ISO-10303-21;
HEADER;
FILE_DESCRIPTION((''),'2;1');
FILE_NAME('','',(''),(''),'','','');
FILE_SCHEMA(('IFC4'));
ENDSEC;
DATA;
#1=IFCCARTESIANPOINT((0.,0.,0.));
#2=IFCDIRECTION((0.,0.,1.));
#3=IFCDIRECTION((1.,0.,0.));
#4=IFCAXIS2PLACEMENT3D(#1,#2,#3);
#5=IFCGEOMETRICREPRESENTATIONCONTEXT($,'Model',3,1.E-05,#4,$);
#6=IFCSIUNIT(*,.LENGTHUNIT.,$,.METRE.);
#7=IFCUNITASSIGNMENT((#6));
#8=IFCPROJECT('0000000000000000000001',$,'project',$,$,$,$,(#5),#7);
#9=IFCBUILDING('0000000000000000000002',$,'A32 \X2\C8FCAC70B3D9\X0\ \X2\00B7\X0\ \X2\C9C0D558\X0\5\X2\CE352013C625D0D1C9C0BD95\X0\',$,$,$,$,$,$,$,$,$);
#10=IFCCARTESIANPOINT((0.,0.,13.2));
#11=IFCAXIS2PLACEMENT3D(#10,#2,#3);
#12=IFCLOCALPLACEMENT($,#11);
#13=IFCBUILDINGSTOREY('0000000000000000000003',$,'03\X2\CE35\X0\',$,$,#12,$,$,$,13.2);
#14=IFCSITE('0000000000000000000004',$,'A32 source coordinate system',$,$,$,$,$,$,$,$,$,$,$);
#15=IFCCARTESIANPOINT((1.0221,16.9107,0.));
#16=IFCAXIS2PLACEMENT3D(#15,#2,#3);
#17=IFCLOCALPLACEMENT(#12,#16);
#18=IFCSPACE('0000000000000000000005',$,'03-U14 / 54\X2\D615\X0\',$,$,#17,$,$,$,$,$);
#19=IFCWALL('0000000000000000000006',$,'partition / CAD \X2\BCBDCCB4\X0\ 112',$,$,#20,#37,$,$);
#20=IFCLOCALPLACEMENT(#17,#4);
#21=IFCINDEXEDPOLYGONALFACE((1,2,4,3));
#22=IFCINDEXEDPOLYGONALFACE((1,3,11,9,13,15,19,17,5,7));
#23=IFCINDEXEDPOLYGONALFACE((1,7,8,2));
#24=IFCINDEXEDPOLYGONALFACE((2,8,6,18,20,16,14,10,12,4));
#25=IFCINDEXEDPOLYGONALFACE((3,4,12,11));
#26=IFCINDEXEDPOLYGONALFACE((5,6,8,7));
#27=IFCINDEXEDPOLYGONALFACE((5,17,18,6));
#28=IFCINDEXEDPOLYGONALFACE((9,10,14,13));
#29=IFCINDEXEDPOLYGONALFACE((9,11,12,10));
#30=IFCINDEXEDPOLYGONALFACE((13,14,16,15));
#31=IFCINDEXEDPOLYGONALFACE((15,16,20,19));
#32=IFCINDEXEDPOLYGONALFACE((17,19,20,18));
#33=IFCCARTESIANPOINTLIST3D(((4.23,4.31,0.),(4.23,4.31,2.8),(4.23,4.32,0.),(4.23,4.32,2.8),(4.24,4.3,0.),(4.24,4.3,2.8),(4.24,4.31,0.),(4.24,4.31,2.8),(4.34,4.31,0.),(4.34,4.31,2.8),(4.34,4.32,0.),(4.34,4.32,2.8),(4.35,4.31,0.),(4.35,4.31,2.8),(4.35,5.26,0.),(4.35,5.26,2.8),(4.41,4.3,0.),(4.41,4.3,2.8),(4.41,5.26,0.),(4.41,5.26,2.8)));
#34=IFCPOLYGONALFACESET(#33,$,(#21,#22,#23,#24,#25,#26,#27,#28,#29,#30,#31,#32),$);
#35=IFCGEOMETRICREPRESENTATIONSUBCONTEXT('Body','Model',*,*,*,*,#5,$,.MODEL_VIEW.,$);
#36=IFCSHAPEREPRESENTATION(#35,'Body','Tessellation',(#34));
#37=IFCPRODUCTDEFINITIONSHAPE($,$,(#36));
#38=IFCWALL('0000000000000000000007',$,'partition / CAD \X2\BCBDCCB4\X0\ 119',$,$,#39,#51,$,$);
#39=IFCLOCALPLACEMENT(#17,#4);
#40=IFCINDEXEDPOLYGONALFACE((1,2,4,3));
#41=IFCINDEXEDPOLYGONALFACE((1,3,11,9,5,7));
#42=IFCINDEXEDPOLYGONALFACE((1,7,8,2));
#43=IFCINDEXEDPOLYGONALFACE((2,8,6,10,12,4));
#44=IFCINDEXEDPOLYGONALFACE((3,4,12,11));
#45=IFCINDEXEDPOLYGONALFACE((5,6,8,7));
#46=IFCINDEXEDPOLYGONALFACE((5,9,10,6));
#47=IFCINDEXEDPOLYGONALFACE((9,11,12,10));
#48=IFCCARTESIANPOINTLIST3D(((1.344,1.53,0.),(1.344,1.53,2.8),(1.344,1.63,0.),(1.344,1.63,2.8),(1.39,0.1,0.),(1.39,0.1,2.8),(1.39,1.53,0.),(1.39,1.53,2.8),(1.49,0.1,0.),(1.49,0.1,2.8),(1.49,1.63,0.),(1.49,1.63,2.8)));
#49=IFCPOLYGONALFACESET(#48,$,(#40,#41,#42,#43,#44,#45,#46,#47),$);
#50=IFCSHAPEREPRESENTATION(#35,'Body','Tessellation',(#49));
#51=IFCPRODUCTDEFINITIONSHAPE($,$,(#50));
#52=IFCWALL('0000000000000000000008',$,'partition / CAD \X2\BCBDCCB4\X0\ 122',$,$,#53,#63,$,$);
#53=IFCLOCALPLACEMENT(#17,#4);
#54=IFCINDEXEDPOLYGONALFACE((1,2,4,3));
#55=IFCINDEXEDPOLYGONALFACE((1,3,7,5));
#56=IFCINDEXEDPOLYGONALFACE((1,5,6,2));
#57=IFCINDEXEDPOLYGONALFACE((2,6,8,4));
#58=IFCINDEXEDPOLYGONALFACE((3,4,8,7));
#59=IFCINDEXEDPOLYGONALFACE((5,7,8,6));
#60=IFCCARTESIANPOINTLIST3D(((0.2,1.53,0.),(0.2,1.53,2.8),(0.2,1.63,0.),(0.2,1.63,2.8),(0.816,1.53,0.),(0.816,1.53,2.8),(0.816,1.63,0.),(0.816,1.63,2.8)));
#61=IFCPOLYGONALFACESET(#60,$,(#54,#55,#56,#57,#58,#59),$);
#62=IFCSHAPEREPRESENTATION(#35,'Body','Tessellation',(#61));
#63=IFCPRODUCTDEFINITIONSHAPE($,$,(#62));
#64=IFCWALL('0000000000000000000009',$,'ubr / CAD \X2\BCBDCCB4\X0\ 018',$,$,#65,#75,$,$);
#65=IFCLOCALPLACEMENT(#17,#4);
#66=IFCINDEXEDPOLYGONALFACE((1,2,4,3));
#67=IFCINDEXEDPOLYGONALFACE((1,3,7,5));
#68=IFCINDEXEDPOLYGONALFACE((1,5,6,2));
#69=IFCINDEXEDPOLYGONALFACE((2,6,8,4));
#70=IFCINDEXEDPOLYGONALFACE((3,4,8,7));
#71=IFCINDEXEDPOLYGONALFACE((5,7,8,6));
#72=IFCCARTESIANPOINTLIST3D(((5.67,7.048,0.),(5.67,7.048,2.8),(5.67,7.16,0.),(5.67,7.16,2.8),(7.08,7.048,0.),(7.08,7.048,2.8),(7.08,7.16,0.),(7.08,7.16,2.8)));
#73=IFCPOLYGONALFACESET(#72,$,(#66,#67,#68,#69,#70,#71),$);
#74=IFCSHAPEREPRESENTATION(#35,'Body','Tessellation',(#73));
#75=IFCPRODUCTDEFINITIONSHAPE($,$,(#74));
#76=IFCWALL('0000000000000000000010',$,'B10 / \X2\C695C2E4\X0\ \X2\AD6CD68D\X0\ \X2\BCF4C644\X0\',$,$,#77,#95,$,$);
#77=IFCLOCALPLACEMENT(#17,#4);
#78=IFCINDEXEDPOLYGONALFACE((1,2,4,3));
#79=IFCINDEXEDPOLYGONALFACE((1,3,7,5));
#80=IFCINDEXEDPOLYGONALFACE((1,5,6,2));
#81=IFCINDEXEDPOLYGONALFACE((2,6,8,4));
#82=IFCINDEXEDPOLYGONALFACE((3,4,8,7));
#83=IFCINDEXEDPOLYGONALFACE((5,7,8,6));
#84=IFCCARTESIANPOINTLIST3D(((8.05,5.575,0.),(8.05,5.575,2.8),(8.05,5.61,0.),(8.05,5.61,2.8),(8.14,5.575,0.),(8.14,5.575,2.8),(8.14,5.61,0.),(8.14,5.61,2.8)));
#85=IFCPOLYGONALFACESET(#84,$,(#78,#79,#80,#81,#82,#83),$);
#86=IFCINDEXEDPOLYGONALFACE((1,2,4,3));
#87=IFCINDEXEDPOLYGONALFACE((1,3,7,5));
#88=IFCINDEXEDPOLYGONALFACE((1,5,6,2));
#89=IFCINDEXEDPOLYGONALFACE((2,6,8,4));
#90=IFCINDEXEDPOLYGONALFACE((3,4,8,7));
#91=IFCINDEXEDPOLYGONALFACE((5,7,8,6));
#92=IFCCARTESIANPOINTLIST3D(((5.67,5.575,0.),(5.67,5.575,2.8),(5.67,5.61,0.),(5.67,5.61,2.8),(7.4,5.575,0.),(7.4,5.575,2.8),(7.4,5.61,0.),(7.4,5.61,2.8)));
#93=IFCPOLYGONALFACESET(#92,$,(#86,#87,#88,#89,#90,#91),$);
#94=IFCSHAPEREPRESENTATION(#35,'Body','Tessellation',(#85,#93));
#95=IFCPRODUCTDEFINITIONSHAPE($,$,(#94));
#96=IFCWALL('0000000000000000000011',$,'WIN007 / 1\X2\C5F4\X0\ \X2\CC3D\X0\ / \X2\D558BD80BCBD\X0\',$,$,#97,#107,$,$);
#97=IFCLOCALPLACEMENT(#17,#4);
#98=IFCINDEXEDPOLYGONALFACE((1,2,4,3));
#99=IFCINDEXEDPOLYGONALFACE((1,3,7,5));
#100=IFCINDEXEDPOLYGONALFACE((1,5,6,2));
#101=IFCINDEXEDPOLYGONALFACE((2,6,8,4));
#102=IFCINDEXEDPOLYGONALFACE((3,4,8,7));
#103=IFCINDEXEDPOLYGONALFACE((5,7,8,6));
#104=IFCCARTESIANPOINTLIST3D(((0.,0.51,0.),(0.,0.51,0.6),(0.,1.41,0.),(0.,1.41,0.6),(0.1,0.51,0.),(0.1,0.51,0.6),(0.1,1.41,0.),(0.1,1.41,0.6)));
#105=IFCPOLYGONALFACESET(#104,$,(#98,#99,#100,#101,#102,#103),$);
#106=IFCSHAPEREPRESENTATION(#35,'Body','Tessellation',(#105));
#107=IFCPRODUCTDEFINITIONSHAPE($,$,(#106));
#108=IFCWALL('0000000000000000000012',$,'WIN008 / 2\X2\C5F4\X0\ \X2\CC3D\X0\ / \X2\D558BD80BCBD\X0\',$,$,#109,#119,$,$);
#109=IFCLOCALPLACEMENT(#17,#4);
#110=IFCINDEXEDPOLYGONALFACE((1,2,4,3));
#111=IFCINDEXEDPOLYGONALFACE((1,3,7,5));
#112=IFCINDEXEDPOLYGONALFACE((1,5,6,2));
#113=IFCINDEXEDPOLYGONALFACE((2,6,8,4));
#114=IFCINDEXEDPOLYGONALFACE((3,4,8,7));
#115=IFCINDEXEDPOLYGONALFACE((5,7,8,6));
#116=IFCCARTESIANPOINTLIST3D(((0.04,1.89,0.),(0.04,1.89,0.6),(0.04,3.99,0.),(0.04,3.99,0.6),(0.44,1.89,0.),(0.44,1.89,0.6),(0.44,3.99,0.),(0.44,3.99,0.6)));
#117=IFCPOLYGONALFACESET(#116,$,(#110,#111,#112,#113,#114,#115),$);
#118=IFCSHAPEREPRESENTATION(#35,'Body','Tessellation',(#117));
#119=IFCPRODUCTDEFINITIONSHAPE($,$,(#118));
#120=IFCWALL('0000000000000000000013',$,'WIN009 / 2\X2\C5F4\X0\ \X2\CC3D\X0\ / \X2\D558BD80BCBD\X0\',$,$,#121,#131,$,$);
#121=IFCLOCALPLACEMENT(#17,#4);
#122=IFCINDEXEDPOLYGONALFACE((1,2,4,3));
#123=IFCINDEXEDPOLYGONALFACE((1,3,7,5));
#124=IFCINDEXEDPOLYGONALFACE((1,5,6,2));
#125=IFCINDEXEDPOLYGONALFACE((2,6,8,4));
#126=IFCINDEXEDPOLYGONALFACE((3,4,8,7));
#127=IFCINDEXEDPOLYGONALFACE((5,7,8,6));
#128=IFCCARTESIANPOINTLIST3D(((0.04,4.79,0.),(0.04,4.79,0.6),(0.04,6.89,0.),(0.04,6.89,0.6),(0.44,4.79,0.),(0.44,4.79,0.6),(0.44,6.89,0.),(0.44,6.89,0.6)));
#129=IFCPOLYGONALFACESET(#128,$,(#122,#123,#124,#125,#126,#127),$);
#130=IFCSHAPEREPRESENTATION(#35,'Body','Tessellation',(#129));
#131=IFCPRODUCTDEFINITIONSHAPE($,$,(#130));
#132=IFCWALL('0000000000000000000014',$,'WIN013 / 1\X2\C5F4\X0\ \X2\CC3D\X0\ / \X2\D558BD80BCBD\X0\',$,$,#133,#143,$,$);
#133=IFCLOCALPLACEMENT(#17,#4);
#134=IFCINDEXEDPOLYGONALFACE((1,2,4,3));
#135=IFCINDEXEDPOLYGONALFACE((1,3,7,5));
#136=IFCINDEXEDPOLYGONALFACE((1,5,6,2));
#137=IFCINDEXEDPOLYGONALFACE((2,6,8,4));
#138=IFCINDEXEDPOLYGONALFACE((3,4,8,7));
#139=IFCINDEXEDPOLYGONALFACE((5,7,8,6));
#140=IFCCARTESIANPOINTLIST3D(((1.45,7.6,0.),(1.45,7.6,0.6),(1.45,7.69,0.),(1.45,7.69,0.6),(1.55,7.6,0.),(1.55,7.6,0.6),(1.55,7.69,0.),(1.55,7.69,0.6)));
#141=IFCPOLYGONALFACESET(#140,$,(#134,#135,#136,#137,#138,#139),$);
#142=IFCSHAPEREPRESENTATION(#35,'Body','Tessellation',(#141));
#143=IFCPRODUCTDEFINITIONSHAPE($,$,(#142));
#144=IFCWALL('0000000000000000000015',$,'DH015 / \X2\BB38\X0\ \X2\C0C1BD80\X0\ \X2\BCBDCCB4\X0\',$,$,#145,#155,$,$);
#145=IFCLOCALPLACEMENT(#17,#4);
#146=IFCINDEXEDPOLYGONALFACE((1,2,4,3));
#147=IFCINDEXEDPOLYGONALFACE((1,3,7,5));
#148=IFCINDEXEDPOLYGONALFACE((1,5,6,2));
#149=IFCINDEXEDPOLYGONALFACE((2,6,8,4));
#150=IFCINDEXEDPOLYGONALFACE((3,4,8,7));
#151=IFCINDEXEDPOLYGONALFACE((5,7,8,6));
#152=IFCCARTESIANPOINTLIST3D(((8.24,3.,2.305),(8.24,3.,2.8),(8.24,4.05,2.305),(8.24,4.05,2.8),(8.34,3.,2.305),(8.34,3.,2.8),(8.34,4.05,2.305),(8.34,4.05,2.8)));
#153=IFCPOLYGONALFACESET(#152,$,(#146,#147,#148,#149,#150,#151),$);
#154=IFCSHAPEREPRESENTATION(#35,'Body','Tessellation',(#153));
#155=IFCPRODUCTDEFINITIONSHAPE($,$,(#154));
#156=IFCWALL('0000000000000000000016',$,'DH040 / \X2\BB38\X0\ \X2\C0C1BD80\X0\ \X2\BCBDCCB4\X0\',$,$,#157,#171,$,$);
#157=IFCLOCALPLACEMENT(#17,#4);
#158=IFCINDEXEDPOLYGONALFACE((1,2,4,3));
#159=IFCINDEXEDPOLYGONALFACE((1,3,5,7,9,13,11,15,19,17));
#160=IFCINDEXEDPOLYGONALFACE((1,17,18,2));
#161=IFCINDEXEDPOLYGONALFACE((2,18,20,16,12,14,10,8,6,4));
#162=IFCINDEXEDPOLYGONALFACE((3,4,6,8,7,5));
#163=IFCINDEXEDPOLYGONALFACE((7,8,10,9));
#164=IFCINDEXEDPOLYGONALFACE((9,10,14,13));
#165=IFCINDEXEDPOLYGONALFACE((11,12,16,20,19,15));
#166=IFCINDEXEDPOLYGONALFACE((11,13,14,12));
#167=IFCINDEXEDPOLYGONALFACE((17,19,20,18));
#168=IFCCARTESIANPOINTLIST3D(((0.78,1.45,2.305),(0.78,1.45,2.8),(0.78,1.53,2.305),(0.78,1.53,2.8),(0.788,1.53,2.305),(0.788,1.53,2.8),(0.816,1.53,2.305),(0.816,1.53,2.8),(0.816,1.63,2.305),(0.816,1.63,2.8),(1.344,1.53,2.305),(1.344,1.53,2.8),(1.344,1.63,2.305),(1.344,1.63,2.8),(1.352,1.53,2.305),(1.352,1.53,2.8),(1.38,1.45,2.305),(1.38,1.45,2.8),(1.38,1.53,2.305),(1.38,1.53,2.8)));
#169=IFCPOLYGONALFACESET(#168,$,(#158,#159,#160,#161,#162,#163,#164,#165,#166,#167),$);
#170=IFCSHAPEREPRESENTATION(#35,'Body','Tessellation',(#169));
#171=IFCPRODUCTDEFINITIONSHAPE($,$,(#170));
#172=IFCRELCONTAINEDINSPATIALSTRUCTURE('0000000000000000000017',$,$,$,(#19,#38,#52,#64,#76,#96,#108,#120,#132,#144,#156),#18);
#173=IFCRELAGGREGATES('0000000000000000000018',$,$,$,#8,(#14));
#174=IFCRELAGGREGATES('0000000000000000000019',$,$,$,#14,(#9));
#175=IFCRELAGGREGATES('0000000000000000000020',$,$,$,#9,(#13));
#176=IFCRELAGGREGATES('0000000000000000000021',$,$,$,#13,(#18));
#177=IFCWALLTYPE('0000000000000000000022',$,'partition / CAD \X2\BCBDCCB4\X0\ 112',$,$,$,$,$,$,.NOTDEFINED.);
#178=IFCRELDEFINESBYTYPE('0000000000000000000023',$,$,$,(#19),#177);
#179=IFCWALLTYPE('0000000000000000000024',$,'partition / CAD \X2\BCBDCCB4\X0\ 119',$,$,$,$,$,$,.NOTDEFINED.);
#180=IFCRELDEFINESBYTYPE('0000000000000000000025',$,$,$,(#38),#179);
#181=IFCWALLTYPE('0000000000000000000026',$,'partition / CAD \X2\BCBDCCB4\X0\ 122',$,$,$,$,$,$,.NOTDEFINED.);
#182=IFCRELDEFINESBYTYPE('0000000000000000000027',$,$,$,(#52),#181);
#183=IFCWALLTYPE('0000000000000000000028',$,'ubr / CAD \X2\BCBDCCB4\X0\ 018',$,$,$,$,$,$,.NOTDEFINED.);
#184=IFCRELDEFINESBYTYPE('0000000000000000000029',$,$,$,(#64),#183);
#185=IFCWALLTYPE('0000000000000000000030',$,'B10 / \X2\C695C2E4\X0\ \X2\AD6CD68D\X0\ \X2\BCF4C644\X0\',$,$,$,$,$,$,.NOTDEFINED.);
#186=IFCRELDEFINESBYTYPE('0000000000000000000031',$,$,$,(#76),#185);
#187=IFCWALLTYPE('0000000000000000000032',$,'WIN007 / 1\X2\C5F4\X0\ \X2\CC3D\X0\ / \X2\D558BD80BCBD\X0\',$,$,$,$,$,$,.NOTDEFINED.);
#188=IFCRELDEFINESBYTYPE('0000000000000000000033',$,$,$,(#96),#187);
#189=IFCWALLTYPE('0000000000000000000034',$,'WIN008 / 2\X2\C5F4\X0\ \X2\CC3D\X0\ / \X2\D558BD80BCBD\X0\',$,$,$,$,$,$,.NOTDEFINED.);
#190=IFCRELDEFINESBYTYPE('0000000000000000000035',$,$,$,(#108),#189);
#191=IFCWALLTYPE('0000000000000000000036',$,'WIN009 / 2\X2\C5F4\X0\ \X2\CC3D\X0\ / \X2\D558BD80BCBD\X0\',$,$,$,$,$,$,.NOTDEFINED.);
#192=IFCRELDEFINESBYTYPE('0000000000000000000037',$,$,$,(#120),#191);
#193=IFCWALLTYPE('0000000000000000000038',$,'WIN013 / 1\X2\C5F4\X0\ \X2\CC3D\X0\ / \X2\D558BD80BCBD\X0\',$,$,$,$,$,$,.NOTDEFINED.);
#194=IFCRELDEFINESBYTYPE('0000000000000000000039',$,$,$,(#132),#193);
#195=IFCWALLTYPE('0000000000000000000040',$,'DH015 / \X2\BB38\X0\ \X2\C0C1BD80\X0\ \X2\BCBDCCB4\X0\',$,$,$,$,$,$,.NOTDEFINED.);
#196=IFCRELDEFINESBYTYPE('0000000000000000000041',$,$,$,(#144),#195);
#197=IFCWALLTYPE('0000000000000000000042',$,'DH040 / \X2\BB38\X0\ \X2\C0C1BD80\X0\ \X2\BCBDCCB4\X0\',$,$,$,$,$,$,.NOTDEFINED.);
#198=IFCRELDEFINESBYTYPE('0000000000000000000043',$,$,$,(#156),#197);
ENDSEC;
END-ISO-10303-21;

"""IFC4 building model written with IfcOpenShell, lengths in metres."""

from ifc_helpers import new_model, si_unit, frame, origin, origin_with_axes, place, context, subcontext, project, spatial, polyline, outline, extrude, source, transform, mapped, type_object, type_shapes, element, save


model = new_model("IFC4")

# Units and contexts
model_context = context("Model", 3, precision=1e-05, world=origin_with_axes())
body_context = subcontext(model_context, "Body", "Model", "MODEL_VIEW")
ifc_project = project(units=[si_unit("LENGTHUNIT", "METRE")], contexts=[model_context])

# Site, building, storey, space
storey_placement = place(None, frame((0.0, 0.0, 13.2), z_axis=(0.0, 0.0, 1.0), x_axis=(1.0, 0.0, 0.0)))
space_placement = place(storey_placement, frame((1.0221, 16.9107, 0.0), z_axis=(0.0, 0.0, 1.0), x_axis=(1.0, 0.0, 0.0)))
site = spatial("IfcSite", under=ifc_project, Name="A32 source coordinate system")
building = spatial("IfcBuilding", under=site, Name="A32 주거동 · 지하5층–옥탑지붕")
storey = spatial("IfcBuildingStorey", under=building, at=storey_placement, Name="03층", Elevation=13.2)
space = spatial("IfcSpace", under=storey, at=space_placement, Name="03-U14 / 54형")

# Walls
wall_type_1 = type_object("IfcWallType", Name="partition / CAD 벽체 112", PredefinedType="NOTDEFINED")
shared_shape_1 = source(origin(), body_context, "Body", "SweptSolid", [
    extrude(outline(polyline([(4.24, 4.3), (4.24, 4.31), (4.23, 4.31), (4.23, 4.32), (4.34, 4.32), (4.34, 4.31), (4.35, 4.31), (4.35, 5.26), (4.41, 5.26), (4.41, 4.3), (4.24, 4.3)])), origin(), (0.0, 0.0, 1.0), 2.8),
])
type_shapes(wall_type_1, [shared_shape_1])
wall_1_placement = place(space_placement, origin_with_axes())
element("IfcWall", 1, at=wall_1_placement, inside=space, type_object=wall_type_1, Name="partition / CAD 벽체 112", context=body_context, shape_type="MappedRepresentation", body=[
    mapped(shared_shape_1, transform((0.0, 0.0, 0.0), scale=1.0)),
])
wall_type_2 = type_object("IfcWallType", Name="partition / CAD 벽체 119", PredefinedType="NOTDEFINED")
shared_shape_2 = source(origin(), body_context, "Body", "SweptSolid", [
    extrude(outline(polyline([(1.344, 1.53), (1.344, 1.63), (1.49, 1.63), (1.49, 0.1), (1.39, 0.1), (1.39, 1.53), (1.344, 1.53)])), origin(), (0.0, 0.0, 1.0), 2.8),
])
type_shapes(wall_type_2, [shared_shape_2])
wall_2_placement = place(space_placement, origin_with_axes())
element("IfcWall", 2, at=wall_2_placement, inside=space, type_object=wall_type_2, Name="partition / CAD 벽체 119", context=body_context, shape_type="MappedRepresentation", body=[
    mapped(shared_shape_2, transform((0.0, 0.0, 0.0), scale=1.0)),
])
wall_type_3 = type_object("IfcWallType", Name="partition / CAD 벽체 122", PredefinedType="NOTDEFINED")
shared_shape_3 = source(origin(), body_context, "Body", "SweptSolid", [
    extrude(outline(polyline([(0.816, 1.63), (0.816, 1.53), (0.2, 1.53), (0.2, 1.63), (0.816, 1.63)])), origin(), (0.0, 0.0, 1.0), 2.8),
])
type_shapes(wall_type_3, [shared_shape_3])
wall_3_placement = place(space_placement, origin_with_axes())
element("IfcWall", 3, at=wall_3_placement, inside=space, type_object=wall_type_3, Name="partition / CAD 벽체 122", context=body_context, shape_type="MappedRepresentation", body=[
    mapped(shared_shape_3, transform((0.0, 0.0, 0.0), scale=1.0)),
])
wall_type_4 = type_object("IfcWallType", Name="ubr / CAD 벽체 018", PredefinedType="NOTDEFINED")
shared_shape_4 = source(origin(), body_context, "Body", "SweptSolid", [
    extrude(outline(polyline([(5.67, 7.16), (7.08, 7.16), (7.08, 7.048), (5.67, 7.048), (5.67, 7.16)])), origin(), (0.0, 0.0, 1.0), 2.8),
])
type_shapes(wall_type_4, [shared_shape_4])
wall_4_placement = place(space_placement, origin_with_axes())
element("IfcWall", 4, at=wall_4_placement, inside=space, type_object=wall_type_4, Name="ubr / CAD 벽체 018", context=body_context, shape_type="MappedRepresentation", body=[
    mapped(shared_shape_4, transform((0.0, 0.0, 0.0), scale=1.0)),
])
wall_type_5 = type_object("IfcWallType", Name="B10 / 욕실 구획 보완", PredefinedType="NOTDEFINED")
shared_shape_5 = source(origin(), body_context, "Body", "SweptSolid", [
    extrude(outline(polyline([(8.14, 5.575), (8.05, 5.575), (8.05, 5.61), (8.14, 5.61), (8.14, 5.575)])), origin(), (0.0, 0.0, 1.0), 2.8),
    extrude(outline(polyline([(7.4, 5.575), (5.67, 5.575), (5.67, 5.61), (7.4, 5.61), (7.4, 5.575)])), origin(), (0.0, 0.0, 1.0), 2.8),
])
type_shapes(wall_type_5, [shared_shape_5])
wall_5_placement = place(space_placement, origin_with_axes())
element("IfcWall", 5, at=wall_5_placement, inside=space, type_object=wall_type_5, Name="B10 / 욕실 구획 보완", context=body_context, shape_type="MappedRepresentation", body=[
    mapped(shared_shape_5, transform((0.0, 0.0, 0.0), scale=1.0)),
])
wall_type_6 = type_object("IfcWallType", Name="WIN007 / 1열 창 / 하부벽", PredefinedType="NOTDEFINED")
shared_shape_6 = source(origin(), body_context, "Body", "SweptSolid", [
    extrude(outline(polyline([(0.1, 1.41), (0.1, 0.51), (0.0, 0.51), (0.0, 1.41), (0.1, 1.41)])), origin(), (0.0, 0.0, 1.0), 0.6),
])
type_shapes(wall_type_6, [shared_shape_6])
wall_6_placement = place(space_placement, origin_with_axes())
element("IfcWall", 6, at=wall_6_placement, inside=space, type_object=wall_type_6, Name="WIN007 / 1열 창 / 하부벽", context=body_context, shape_type="MappedRepresentation", body=[
    mapped(shared_shape_6, transform((0.0, 0.0, 0.0), scale=1.0)),
])
wall_type_7 = type_object("IfcWallType", Name="WIN008 / 2열 창 / 하부벽", PredefinedType="NOTDEFINED")
shared_shape_7 = source(origin(), body_context, "Body", "SweptSolid", [
    extrude(outline(polyline([(0.44, 3.99), (0.44, 1.89), (0.04, 1.89), (0.04, 3.99), (0.44, 3.99)])), origin(), (0.0, 0.0, 1.0), 0.6),
])
type_shapes(wall_type_7, [shared_shape_7])
wall_7_placement = place(space_placement, origin_with_axes())
element("IfcWall", 7, at=wall_7_placement, inside=space, type_object=wall_type_7, Name="WIN008 / 2열 창 / 하부벽", context=body_context, shape_type="MappedRepresentation", body=[
    mapped(shared_shape_7, transform((0.0, 0.0, 0.0), scale=1.0)),
])
wall_type_8 = type_object("IfcWallType", Name="WIN009 / 2열 창 / 하부벽", PredefinedType="NOTDEFINED")
shared_shape_8 = source(origin(), body_context, "Body", "SweptSolid", [
    extrude(outline(polyline([(0.44, 6.89), (0.44, 4.79), (0.04, 4.79), (0.04, 6.89), (0.44, 6.89)])), origin(), (0.0, 0.0, 1.0), 0.6),
])
type_shapes(wall_type_8, [shared_shape_8])
wall_8_placement = place(space_placement, origin_with_axes())
element("IfcWall", 8, at=wall_8_placement, inside=space, type_object=wall_type_8, Name="WIN009 / 2열 창 / 하부벽", context=body_context, shape_type="MappedRepresentation", body=[
    mapped(shared_shape_8, transform((0.0, 0.0, 0.0), scale=1.0)),
])
wall_type_9 = type_object("IfcWallType", Name="WIN013 / 1열 창 / 하부벽", PredefinedType="NOTDEFINED")
shared_shape_9 = source(origin(), body_context, "Body", "SweptSolid", [
    extrude(outline(polyline([(1.55, 7.6), (1.45, 7.6), (1.45, 7.69), (1.55, 7.69), (1.55, 7.6)])), origin(), (0.0, 0.0, 1.0), 0.6),
])
type_shapes(wall_type_9, [shared_shape_9])
wall_9_placement = place(space_placement, origin_with_axes())
element("IfcWall", 9, at=wall_9_placement, inside=space, type_object=wall_type_9, Name="WIN013 / 1열 창 / 하부벽", context=body_context, shape_type="MappedRepresentation", body=[
    mapped(shared_shape_9, transform((0.0, 0.0, 0.0), scale=1.0)),
])
wall_type_10 = type_object("IfcWallType", Name="DH015 / 문 상부 벽체", PredefinedType="NOTDEFINED")
shared_shape_10 = source(origin(), body_context, "Body", "SweptSolid", [
    extrude(outline(polyline([(8.34, 3.0), (8.24, 3.0), (8.24, 4.05), (8.34, 4.05), (8.34, 3.0)])), frame((0.0, 0.0, 2.305)), (0.0, 0.0, 1.0), 0.495),
])
type_shapes(wall_type_10, [shared_shape_10])
wall_10_placement = place(space_placement, origin_with_axes())
element("IfcWall", 10, at=wall_10_placement, inside=space, type_object=wall_type_10, Name="DH015 / 문 상부 벽체", context=body_context, shape_type="MappedRepresentation", body=[
    mapped(shared_shape_10, transform((0.0, 0.0, 0.0), scale=1.0)),
])
wall_type_11 = type_object("IfcWallType", Name="DH040 / 문 상부 벽체", PredefinedType="NOTDEFINED")
shared_shape_11 = source(origin(), body_context, "Body", "SweptSolid", [
    extrude(outline(polyline([(0.816, 1.63), (1.344, 1.63), (1.344, 1.53), (1.352, 1.53), (1.38, 1.53), (1.38, 1.45), (0.78, 1.45), (0.78, 1.53), (0.788, 1.53), (0.816, 1.53), (0.816, 1.63)])), frame((0.0, 0.0, 2.305)), (0.0, 0.0, 1.0), 0.495),
])
type_shapes(wall_type_11, [shared_shape_11])
wall_11_placement = place(space_placement, origin_with_axes())
element("IfcWall", 11, at=wall_11_placement, inside=space, type_object=wall_type_11, Name="DH040 / 문 상부 벽체", context=body_context, shape_type="MappedRepresentation", body=[
    mapped(shared_shape_11, transform((0.0, 0.0, 0.0), scale=1.0)),
])

save(model, "model.ifc")
